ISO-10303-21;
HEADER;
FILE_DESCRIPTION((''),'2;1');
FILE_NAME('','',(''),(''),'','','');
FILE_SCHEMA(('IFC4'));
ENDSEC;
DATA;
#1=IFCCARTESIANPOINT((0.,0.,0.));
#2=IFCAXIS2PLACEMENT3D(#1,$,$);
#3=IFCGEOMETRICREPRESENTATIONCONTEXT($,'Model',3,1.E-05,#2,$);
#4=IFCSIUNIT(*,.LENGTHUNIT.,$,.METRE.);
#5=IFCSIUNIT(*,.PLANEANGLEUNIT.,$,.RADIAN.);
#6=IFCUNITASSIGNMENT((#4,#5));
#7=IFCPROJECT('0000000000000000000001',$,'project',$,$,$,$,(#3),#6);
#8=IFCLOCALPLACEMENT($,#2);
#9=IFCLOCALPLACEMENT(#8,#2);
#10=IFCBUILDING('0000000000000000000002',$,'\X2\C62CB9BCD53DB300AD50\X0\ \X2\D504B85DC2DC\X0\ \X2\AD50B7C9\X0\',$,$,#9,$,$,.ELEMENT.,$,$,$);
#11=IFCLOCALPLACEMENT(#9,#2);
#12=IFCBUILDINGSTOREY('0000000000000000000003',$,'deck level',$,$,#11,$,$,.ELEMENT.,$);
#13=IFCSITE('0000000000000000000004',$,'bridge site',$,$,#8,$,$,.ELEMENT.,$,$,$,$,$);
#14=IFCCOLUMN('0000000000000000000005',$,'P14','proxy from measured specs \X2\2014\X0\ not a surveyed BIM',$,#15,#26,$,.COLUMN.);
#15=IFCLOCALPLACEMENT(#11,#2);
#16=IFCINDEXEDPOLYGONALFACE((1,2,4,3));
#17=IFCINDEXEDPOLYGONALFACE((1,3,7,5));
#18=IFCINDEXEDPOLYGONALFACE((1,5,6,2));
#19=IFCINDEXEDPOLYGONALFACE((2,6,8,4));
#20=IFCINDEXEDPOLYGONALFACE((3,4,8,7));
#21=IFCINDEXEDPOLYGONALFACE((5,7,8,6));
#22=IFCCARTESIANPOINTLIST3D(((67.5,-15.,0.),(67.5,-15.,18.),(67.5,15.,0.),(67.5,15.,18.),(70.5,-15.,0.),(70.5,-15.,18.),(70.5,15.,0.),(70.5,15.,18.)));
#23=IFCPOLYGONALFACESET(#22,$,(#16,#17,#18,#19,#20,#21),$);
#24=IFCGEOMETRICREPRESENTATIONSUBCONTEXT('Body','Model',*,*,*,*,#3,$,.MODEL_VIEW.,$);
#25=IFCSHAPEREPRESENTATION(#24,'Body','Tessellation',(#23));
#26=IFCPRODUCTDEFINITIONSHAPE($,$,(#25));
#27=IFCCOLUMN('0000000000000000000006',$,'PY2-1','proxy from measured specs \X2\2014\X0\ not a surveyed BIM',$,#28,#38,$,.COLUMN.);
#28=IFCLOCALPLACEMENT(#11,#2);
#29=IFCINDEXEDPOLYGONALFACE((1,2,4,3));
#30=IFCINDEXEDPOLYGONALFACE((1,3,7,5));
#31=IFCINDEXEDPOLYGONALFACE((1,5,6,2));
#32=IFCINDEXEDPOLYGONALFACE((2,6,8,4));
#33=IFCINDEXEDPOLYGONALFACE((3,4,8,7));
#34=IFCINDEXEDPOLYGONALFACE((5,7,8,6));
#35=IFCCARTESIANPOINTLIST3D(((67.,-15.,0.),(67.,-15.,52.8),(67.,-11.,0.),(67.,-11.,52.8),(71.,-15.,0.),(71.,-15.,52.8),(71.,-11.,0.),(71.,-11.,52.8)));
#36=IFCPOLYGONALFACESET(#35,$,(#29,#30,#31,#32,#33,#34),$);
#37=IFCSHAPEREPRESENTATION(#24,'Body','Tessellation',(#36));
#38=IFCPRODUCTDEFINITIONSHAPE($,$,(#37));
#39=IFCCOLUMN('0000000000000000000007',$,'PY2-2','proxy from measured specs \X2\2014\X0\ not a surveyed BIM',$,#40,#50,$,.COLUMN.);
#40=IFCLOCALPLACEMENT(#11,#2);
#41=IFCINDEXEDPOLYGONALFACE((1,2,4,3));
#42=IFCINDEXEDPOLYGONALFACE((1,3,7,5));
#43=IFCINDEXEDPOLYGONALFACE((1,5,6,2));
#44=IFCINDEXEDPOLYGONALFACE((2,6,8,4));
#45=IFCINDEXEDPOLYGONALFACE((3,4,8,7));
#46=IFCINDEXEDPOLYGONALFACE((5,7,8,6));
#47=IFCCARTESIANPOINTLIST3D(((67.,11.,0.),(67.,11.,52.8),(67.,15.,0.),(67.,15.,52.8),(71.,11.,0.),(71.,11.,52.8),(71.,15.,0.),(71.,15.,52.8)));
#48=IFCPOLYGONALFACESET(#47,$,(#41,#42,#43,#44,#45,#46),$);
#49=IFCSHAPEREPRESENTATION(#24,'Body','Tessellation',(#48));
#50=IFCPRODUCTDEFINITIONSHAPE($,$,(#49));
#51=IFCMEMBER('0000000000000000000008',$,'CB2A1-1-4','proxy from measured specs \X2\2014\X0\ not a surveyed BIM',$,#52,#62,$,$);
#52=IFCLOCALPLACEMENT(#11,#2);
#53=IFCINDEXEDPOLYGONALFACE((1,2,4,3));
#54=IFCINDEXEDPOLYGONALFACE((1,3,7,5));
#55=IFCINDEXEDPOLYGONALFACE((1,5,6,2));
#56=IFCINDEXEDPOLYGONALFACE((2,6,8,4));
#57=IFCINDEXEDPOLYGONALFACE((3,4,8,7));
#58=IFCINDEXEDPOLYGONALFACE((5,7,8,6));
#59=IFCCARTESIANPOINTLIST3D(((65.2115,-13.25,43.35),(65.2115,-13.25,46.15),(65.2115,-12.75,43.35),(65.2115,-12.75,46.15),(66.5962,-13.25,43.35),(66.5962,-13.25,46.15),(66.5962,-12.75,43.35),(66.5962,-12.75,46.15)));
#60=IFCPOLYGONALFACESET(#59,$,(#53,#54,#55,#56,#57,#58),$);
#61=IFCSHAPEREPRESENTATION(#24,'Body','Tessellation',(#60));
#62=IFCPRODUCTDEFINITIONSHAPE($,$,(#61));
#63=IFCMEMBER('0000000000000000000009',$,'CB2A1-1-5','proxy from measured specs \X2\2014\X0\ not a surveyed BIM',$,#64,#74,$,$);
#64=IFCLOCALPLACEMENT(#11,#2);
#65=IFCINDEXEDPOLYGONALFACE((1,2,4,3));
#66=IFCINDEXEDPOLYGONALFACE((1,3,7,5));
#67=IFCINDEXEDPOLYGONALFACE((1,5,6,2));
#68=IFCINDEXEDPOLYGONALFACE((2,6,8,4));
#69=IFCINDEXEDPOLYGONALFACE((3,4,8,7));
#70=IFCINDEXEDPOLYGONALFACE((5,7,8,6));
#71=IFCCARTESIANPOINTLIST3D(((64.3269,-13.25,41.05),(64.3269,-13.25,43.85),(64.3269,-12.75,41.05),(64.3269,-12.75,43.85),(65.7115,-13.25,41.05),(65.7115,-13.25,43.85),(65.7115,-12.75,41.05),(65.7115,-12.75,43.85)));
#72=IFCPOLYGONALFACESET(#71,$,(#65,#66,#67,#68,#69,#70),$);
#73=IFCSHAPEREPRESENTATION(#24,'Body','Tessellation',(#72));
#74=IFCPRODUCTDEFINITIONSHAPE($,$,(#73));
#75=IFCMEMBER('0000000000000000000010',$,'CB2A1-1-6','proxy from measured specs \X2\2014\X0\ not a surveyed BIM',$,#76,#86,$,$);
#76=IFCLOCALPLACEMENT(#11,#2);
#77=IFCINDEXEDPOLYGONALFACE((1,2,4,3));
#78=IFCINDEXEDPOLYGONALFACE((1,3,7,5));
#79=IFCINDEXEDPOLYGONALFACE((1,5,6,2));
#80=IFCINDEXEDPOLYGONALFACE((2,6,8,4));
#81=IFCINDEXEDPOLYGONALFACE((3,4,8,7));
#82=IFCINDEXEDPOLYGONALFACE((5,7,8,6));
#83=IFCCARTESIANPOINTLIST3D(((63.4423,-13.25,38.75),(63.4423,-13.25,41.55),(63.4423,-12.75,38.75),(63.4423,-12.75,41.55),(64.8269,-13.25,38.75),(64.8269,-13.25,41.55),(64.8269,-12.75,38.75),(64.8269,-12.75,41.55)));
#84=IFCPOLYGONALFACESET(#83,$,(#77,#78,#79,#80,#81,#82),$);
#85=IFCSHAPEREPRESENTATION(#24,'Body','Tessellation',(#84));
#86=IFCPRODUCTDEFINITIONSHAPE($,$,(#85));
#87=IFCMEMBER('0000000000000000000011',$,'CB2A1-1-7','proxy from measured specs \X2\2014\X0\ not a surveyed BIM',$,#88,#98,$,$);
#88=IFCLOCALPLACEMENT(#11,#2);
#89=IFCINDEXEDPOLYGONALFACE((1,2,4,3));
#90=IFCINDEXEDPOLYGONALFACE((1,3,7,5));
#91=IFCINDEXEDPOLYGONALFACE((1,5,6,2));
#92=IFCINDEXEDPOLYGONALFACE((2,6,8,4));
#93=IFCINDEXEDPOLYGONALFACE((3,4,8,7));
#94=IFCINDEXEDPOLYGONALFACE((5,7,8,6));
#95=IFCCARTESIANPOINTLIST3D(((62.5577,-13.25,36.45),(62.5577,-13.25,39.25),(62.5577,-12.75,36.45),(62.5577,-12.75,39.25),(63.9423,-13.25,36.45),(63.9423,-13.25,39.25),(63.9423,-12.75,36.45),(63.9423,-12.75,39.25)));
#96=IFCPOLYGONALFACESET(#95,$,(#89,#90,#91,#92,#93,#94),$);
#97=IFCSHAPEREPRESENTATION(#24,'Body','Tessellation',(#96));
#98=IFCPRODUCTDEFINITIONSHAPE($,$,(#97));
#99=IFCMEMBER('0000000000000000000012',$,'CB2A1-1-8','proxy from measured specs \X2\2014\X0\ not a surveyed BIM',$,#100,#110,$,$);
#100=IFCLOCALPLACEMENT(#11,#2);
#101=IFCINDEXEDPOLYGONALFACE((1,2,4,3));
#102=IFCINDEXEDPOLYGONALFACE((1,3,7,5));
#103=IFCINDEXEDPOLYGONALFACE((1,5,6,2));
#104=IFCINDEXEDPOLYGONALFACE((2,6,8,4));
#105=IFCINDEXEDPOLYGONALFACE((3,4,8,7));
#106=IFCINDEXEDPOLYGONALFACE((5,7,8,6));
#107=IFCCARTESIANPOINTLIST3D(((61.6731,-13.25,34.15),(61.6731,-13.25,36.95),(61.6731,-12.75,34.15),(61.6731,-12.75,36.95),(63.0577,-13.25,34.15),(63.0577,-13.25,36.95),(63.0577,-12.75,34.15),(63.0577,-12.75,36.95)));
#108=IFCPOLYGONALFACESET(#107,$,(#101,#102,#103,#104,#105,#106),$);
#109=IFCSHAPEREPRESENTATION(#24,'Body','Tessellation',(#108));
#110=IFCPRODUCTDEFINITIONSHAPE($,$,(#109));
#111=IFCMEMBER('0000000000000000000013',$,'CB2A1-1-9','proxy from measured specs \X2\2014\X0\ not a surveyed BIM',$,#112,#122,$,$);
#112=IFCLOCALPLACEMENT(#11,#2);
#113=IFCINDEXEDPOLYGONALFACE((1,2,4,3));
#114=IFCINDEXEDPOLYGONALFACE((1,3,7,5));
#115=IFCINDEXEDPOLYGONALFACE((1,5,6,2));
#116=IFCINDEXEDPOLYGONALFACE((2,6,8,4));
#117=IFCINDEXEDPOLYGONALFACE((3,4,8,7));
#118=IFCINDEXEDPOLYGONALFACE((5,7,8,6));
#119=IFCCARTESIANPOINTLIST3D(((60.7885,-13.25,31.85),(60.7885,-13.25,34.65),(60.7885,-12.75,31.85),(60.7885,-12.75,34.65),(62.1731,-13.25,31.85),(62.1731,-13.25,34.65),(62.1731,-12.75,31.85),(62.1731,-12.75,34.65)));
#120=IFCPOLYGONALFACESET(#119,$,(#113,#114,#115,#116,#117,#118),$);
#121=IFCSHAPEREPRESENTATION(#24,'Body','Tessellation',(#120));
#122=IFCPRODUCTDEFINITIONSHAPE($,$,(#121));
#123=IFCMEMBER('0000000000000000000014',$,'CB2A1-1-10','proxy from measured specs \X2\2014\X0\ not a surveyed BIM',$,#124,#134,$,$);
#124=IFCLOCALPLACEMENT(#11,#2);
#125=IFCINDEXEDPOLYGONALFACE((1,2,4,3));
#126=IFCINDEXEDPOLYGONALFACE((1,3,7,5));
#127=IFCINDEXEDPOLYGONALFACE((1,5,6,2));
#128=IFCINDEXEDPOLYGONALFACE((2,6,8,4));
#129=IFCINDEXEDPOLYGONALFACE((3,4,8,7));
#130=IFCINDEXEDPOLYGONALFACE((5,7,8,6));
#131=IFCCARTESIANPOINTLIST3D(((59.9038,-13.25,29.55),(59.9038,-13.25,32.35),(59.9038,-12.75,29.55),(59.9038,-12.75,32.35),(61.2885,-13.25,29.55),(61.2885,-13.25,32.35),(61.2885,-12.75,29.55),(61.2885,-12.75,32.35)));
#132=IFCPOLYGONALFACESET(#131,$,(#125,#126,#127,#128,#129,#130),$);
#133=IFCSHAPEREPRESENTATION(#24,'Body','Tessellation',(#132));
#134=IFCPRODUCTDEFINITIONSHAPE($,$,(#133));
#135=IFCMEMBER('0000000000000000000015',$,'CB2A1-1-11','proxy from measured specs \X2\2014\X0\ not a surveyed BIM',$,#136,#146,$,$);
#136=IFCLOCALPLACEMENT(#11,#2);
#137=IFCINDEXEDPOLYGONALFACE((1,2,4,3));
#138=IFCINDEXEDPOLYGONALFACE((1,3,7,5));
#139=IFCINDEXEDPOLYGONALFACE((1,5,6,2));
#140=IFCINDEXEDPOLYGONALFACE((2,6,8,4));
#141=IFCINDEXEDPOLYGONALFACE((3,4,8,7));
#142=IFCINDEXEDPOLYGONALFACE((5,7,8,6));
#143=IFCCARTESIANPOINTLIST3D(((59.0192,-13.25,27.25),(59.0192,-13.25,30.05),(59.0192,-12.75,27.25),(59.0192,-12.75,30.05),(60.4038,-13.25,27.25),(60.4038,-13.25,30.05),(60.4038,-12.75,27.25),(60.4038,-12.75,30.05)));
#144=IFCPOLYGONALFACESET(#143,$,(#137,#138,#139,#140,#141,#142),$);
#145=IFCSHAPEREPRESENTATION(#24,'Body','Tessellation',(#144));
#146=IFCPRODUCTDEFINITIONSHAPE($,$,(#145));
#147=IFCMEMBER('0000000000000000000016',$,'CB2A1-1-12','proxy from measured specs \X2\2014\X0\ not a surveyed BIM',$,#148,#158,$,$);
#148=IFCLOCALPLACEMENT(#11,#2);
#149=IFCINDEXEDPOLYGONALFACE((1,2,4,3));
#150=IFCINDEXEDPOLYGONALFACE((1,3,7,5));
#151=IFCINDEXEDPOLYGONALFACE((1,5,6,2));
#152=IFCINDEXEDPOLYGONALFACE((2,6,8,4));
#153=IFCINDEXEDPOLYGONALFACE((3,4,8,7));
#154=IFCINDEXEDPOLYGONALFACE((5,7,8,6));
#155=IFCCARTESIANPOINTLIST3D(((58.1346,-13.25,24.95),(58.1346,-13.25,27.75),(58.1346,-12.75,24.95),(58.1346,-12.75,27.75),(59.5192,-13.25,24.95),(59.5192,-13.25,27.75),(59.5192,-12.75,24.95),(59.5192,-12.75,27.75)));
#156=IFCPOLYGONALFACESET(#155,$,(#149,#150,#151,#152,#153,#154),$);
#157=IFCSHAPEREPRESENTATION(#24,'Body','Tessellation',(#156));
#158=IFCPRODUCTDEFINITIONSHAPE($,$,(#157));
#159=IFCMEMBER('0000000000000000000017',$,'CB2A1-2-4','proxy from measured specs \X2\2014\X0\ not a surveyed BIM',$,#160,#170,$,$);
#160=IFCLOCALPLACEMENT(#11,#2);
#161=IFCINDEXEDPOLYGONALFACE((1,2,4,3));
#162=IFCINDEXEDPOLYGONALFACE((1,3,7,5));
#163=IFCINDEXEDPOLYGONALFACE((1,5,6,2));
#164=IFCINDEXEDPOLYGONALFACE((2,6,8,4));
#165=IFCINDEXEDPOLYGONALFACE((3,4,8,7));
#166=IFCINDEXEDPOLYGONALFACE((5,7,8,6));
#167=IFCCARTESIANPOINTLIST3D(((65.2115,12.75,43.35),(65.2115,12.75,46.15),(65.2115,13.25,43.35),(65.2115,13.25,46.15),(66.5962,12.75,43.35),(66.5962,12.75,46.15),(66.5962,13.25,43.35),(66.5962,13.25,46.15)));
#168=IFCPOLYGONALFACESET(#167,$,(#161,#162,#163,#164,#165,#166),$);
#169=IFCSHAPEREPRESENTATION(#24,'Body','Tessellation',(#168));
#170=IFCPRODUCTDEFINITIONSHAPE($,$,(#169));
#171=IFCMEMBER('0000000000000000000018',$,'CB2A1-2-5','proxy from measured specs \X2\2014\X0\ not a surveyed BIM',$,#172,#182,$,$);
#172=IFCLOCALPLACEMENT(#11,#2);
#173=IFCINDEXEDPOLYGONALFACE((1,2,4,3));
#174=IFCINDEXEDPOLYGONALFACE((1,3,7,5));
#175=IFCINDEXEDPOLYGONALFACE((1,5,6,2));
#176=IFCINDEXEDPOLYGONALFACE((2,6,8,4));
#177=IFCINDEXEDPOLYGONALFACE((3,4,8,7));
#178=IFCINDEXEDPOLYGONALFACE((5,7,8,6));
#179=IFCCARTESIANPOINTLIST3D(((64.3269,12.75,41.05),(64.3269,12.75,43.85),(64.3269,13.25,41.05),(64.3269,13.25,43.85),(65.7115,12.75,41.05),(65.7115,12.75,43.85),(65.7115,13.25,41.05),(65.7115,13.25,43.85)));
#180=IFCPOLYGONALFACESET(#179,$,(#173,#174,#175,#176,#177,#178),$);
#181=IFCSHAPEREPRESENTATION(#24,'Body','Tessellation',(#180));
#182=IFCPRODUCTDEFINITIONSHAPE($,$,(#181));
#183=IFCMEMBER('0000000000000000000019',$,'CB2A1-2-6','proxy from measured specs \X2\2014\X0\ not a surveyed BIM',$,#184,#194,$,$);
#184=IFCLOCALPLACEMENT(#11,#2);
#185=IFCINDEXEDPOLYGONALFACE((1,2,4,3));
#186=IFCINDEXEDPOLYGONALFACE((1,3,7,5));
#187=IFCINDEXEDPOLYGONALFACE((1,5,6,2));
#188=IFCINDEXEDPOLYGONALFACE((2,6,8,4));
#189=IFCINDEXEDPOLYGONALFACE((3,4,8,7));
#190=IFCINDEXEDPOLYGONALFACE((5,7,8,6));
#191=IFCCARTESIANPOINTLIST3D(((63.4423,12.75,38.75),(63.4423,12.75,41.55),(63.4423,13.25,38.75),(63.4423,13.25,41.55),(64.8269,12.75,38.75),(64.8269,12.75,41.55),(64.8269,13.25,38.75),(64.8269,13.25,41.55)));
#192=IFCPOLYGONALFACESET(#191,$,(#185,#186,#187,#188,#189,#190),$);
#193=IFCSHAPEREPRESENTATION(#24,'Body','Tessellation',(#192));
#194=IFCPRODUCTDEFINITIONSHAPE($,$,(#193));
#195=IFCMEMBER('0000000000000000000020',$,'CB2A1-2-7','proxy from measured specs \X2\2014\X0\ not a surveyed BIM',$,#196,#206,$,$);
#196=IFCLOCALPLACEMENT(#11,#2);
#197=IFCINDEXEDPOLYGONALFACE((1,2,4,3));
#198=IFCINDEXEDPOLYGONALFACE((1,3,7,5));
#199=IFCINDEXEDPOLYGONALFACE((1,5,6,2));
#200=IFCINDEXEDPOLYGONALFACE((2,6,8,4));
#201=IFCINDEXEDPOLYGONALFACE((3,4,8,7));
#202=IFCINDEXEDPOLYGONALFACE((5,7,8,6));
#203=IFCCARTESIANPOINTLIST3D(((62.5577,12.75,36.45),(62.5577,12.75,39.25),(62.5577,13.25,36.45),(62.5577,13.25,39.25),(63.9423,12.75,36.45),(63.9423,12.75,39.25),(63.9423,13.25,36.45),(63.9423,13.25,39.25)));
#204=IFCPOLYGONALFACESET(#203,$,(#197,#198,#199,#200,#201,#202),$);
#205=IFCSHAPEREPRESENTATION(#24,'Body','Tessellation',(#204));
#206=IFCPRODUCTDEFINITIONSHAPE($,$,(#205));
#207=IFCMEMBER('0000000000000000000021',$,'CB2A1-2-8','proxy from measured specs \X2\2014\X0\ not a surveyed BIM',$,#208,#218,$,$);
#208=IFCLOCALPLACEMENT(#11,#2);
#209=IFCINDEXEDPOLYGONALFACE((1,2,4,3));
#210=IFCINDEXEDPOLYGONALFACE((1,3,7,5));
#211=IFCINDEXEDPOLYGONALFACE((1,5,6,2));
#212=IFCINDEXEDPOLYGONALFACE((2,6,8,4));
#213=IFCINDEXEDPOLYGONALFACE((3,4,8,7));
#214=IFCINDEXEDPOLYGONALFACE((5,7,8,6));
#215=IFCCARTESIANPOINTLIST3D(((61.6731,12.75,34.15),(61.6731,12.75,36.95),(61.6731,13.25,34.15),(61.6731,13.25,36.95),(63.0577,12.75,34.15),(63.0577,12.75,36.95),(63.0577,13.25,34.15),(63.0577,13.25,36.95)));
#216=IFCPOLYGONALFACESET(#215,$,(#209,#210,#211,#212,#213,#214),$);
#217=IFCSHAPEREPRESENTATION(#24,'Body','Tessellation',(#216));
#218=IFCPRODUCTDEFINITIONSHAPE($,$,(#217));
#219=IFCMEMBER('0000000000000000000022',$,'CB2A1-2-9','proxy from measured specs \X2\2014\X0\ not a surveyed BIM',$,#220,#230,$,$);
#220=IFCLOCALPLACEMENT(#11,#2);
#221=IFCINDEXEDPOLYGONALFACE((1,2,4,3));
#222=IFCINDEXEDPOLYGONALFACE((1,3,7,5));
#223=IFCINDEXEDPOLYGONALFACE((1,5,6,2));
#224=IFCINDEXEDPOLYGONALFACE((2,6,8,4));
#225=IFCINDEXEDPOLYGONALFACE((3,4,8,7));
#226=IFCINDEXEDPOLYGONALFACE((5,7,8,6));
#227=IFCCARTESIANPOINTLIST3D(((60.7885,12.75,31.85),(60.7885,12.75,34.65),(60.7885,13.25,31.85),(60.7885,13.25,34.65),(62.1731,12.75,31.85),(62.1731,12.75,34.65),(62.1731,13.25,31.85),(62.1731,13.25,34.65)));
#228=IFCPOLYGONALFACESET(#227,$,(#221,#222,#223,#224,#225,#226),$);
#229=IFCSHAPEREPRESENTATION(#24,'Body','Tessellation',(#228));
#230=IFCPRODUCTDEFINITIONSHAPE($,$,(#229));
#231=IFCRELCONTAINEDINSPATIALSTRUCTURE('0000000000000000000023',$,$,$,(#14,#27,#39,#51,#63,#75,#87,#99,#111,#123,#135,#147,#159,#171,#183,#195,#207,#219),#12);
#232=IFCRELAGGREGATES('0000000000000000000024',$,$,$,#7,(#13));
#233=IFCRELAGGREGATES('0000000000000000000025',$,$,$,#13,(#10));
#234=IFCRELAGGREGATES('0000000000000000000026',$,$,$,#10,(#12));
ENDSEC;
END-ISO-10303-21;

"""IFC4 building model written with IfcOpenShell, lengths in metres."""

from ifc_helpers import new_model, si_unit, frame, origin, origin_2d, place, context, subcontext, project, spatial, rectangle, extrude, element, save


model = new_model("IFC4")

# Units and contexts
model_context = context("Model", 3, precision=1e-05, world=origin())
body_context = subcontext(model_context, "Body", "Model", "MODEL_VIEW")
ifc_project = project(units=[si_unit("LENGTHUNIT", "METRE"), si_unit("PLANEANGLEUNIT", "RADIAN")], contexts=[model_context])

# Site, building, storey
site_placement = place(None, origin())
site = spatial("IfcSite", under=ifc_project, at=site_placement, Name="bridge site", CompositionType="ELEMENT")
building_placement = place(site_placement, origin())
building = spatial("IfcBuilding", under=site, at=building_placement, Name="올림픽대교 프록시 교량", CompositionType="ELEMENT")
storey_placement = place(building_placement, origin())
storey = spatial("IfcBuildingStorey", under=building, at=storey_placement, Name="deck level", CompositionType="ELEMENT")

# Columns
column_placement = place(storey_placement, frame((69.0, 0.0, 0.0)))
element("IfcColumn", 1, at=column_placement, inside=storey, Name="P14", Description="proxy from measured specs — not a surveyed BIM", PredefinedType="COLUMN", context=body_context, shape_type="SweptSolid", body=[
    extrude(rectangle(XDim=3.0, YDim=30.0, at=origin_2d()), origin(), (0.0, 0.0, 1.0), 18.0),
])
for number, where, name in (
    (2, (69.0, -13.0, 0.0), "PY2-1"),
    (3, (69.0, 13.0, 0.0), "PY2-2"),
):
    element("IfcColumn", number, at=place(storey_placement, frame(where)), inside=storey, Name=name, Description="proxy from measured specs — not a surveyed BIM", PredefinedType="COLUMN", context=body_context, shape_type="SweptSolid", body=[
        extrude(rectangle(XDim=4.0, YDim=4.0, at=origin_2d()), origin(), (0.0, 0.0, 1.0), 52.8),
    ])

# Members
member_1_placement = place(storey_placement, frame((65.9038, -13.0, 43.35)))
element("IfcMember", 4, at=member_1_placement, inside=storey, Name="CB2A1-1-4", Description="proxy from measured specs — not a surveyed BIM", context=body_context, shape_type="SweptSolid", body=[
    extrude(rectangle(XDim=1.3846, YDim=0.5, at=origin_2d()), origin(), (0.0, 0.0, 1.0), 2.8),
])
for number, where, name in (
    (5, (65.0192, -13.0, 41.05), "CB2A1-1-5"),
    (6, (64.1346, -13.0, 38.75), "CB2A1-1-6"),
    (7, (63.25, -13.0, 36.45), "CB2A1-1-7"),
):
    element("IfcMember", number, at=place(storey_placement, frame(where)), inside=storey, Name=name, Description="proxy from measured specs — not a surveyed BIM", context=body_context, shape_type="SweptSolid", body=[
        extrude(rectangle(XDim=1.3846, YDim=0.5, at=origin_2d()), origin(), (0.0, 0.0, 1.0), 2.8),
    ])
member_2_placement = place(storey_placement, frame((62.3654, -13.0, 34.15)))
element("IfcMember", 8, at=member_2_placement, inside=storey, Name="CB2A1-1-8", Description="proxy from measured specs — not a surveyed BIM", context=body_context, shape_type="SweptSolid", body=[
    extrude(rectangle(XDim=1.3846, YDim=0.5, at=origin_2d()), origin(), (0.0, 0.0, 1.0), 2.8),
])
member_3_placement = place(storey_placement, frame((61.4808, -13.0, 31.85)))
element("IfcMember", 9, at=member_3_placement, inside=storey, Name="CB2A1-1-9", Description="proxy from measured specs — not a surveyed BIM", context=body_context, shape_type="SweptSolid", body=[
    extrude(rectangle(XDim=1.3846, YDim=0.5, at=origin_2d()), origin(), (0.0, 0.0, 1.0), 2.8),
])
member_4_placement = place(storey_placement, frame((60.5962, -13.0, 29.55)))
element("IfcMember", 10, at=member_4_placement, inside=storey, Name="CB2A1-1-10", Description="proxy from measured specs — not a surveyed BIM", context=body_context, shape_type="SweptSolid", body=[
    extrude(rectangle(XDim=1.3846, YDim=0.5, at=origin_2d()), origin(), (0.0, 0.0, 1.0), 2.8),
])
member_5_placement = place(storey_placement, frame((59.7115, -13.0, 27.25)))
element("IfcMember", 11, at=member_5_placement, inside=storey, Name="CB2A1-1-11", Description="proxy from measured specs — not a surveyed BIM", context=body_context, shape_type="SweptSolid", body=[
    extrude(rectangle(XDim=1.3846, YDim=0.5, at=origin_2d()), origin(), (0.0, 0.0, 1.0), 2.8),
])
member_6_placement = place(storey_placement, frame((58.8269, -13.0, 24.95)))
element("IfcMember", 12, at=member_6_placement, inside=storey, Name="CB2A1-1-12", Description="proxy from measured specs — not a surveyed BIM", context=body_context, shape_type="SweptSolid", body=[
    extrude(rectangle(XDim=1.3846, YDim=0.5, at=origin_2d()), origin(), (0.0, 0.0, 1.0), 2.8),
])
member_7_placement = place(storey_placement, frame((65.9038, 13.0, 43.35)))
element("IfcMember", 13, at=member_7_placement, inside=storey, Name="CB2A1-2-4", Description="proxy from measured specs — not a surveyed BIM", context=body_context, shape_type="SweptSolid", body=[
    extrude(rectangle(XDim=1.3846, YDim=0.5, at=origin_2d()), origin(), (0.0, 0.0, 1.0), 2.8),
])
for number, where, name in (
    (14, (65.0192, 13.0, 41.05), "CB2A1-2-5"),
    (15, (64.1346, 13.0, 38.75), "CB2A1-2-6"),
    (16, (63.25, 13.0, 36.45), "CB2A1-2-7"),
):
    element("IfcMember", number, at=place(storey_placement, frame(where)), inside=storey, Name=name, Description="proxy from measured specs — not a surveyed BIM", context=body_context, shape_type="SweptSolid", body=[
        extrude(rectangle(XDim=1.3846, YDim=0.5, at=origin_2d()), origin(), (0.0, 0.0, 1.0), 2.8),
    ])
member_8_placement = place(storey_placement, frame((62.3654, 13.0, 34.15)))
element("IfcMember", 17, at=member_8_placement, inside=storey, Name="CB2A1-2-8", Description="proxy from measured specs — not a surveyed BIM", context=body_context, shape_type="SweptSolid", body=[
    extrude(rectangle(XDim=1.3846, YDim=0.5, at=origin_2d()), origin(), (0.0, 0.0, 1.0), 2.8),
])
member_9_placement = place(storey_placement, frame((61.4808, 13.0, 31.85)))
element("IfcMember", 18, at=member_9_placement, inside=storey, Name="CB2A1-2-9", Description="proxy from measured specs — not a surveyed BIM", context=body_context, shape_type="SweptSolid", body=[
    extrude(rectangle(XDim=1.3846, YDim=0.5, at=origin_2d()), origin(), (0.0, 0.0, 1.0), 2.8),
])

save(model, "model.ifc")
